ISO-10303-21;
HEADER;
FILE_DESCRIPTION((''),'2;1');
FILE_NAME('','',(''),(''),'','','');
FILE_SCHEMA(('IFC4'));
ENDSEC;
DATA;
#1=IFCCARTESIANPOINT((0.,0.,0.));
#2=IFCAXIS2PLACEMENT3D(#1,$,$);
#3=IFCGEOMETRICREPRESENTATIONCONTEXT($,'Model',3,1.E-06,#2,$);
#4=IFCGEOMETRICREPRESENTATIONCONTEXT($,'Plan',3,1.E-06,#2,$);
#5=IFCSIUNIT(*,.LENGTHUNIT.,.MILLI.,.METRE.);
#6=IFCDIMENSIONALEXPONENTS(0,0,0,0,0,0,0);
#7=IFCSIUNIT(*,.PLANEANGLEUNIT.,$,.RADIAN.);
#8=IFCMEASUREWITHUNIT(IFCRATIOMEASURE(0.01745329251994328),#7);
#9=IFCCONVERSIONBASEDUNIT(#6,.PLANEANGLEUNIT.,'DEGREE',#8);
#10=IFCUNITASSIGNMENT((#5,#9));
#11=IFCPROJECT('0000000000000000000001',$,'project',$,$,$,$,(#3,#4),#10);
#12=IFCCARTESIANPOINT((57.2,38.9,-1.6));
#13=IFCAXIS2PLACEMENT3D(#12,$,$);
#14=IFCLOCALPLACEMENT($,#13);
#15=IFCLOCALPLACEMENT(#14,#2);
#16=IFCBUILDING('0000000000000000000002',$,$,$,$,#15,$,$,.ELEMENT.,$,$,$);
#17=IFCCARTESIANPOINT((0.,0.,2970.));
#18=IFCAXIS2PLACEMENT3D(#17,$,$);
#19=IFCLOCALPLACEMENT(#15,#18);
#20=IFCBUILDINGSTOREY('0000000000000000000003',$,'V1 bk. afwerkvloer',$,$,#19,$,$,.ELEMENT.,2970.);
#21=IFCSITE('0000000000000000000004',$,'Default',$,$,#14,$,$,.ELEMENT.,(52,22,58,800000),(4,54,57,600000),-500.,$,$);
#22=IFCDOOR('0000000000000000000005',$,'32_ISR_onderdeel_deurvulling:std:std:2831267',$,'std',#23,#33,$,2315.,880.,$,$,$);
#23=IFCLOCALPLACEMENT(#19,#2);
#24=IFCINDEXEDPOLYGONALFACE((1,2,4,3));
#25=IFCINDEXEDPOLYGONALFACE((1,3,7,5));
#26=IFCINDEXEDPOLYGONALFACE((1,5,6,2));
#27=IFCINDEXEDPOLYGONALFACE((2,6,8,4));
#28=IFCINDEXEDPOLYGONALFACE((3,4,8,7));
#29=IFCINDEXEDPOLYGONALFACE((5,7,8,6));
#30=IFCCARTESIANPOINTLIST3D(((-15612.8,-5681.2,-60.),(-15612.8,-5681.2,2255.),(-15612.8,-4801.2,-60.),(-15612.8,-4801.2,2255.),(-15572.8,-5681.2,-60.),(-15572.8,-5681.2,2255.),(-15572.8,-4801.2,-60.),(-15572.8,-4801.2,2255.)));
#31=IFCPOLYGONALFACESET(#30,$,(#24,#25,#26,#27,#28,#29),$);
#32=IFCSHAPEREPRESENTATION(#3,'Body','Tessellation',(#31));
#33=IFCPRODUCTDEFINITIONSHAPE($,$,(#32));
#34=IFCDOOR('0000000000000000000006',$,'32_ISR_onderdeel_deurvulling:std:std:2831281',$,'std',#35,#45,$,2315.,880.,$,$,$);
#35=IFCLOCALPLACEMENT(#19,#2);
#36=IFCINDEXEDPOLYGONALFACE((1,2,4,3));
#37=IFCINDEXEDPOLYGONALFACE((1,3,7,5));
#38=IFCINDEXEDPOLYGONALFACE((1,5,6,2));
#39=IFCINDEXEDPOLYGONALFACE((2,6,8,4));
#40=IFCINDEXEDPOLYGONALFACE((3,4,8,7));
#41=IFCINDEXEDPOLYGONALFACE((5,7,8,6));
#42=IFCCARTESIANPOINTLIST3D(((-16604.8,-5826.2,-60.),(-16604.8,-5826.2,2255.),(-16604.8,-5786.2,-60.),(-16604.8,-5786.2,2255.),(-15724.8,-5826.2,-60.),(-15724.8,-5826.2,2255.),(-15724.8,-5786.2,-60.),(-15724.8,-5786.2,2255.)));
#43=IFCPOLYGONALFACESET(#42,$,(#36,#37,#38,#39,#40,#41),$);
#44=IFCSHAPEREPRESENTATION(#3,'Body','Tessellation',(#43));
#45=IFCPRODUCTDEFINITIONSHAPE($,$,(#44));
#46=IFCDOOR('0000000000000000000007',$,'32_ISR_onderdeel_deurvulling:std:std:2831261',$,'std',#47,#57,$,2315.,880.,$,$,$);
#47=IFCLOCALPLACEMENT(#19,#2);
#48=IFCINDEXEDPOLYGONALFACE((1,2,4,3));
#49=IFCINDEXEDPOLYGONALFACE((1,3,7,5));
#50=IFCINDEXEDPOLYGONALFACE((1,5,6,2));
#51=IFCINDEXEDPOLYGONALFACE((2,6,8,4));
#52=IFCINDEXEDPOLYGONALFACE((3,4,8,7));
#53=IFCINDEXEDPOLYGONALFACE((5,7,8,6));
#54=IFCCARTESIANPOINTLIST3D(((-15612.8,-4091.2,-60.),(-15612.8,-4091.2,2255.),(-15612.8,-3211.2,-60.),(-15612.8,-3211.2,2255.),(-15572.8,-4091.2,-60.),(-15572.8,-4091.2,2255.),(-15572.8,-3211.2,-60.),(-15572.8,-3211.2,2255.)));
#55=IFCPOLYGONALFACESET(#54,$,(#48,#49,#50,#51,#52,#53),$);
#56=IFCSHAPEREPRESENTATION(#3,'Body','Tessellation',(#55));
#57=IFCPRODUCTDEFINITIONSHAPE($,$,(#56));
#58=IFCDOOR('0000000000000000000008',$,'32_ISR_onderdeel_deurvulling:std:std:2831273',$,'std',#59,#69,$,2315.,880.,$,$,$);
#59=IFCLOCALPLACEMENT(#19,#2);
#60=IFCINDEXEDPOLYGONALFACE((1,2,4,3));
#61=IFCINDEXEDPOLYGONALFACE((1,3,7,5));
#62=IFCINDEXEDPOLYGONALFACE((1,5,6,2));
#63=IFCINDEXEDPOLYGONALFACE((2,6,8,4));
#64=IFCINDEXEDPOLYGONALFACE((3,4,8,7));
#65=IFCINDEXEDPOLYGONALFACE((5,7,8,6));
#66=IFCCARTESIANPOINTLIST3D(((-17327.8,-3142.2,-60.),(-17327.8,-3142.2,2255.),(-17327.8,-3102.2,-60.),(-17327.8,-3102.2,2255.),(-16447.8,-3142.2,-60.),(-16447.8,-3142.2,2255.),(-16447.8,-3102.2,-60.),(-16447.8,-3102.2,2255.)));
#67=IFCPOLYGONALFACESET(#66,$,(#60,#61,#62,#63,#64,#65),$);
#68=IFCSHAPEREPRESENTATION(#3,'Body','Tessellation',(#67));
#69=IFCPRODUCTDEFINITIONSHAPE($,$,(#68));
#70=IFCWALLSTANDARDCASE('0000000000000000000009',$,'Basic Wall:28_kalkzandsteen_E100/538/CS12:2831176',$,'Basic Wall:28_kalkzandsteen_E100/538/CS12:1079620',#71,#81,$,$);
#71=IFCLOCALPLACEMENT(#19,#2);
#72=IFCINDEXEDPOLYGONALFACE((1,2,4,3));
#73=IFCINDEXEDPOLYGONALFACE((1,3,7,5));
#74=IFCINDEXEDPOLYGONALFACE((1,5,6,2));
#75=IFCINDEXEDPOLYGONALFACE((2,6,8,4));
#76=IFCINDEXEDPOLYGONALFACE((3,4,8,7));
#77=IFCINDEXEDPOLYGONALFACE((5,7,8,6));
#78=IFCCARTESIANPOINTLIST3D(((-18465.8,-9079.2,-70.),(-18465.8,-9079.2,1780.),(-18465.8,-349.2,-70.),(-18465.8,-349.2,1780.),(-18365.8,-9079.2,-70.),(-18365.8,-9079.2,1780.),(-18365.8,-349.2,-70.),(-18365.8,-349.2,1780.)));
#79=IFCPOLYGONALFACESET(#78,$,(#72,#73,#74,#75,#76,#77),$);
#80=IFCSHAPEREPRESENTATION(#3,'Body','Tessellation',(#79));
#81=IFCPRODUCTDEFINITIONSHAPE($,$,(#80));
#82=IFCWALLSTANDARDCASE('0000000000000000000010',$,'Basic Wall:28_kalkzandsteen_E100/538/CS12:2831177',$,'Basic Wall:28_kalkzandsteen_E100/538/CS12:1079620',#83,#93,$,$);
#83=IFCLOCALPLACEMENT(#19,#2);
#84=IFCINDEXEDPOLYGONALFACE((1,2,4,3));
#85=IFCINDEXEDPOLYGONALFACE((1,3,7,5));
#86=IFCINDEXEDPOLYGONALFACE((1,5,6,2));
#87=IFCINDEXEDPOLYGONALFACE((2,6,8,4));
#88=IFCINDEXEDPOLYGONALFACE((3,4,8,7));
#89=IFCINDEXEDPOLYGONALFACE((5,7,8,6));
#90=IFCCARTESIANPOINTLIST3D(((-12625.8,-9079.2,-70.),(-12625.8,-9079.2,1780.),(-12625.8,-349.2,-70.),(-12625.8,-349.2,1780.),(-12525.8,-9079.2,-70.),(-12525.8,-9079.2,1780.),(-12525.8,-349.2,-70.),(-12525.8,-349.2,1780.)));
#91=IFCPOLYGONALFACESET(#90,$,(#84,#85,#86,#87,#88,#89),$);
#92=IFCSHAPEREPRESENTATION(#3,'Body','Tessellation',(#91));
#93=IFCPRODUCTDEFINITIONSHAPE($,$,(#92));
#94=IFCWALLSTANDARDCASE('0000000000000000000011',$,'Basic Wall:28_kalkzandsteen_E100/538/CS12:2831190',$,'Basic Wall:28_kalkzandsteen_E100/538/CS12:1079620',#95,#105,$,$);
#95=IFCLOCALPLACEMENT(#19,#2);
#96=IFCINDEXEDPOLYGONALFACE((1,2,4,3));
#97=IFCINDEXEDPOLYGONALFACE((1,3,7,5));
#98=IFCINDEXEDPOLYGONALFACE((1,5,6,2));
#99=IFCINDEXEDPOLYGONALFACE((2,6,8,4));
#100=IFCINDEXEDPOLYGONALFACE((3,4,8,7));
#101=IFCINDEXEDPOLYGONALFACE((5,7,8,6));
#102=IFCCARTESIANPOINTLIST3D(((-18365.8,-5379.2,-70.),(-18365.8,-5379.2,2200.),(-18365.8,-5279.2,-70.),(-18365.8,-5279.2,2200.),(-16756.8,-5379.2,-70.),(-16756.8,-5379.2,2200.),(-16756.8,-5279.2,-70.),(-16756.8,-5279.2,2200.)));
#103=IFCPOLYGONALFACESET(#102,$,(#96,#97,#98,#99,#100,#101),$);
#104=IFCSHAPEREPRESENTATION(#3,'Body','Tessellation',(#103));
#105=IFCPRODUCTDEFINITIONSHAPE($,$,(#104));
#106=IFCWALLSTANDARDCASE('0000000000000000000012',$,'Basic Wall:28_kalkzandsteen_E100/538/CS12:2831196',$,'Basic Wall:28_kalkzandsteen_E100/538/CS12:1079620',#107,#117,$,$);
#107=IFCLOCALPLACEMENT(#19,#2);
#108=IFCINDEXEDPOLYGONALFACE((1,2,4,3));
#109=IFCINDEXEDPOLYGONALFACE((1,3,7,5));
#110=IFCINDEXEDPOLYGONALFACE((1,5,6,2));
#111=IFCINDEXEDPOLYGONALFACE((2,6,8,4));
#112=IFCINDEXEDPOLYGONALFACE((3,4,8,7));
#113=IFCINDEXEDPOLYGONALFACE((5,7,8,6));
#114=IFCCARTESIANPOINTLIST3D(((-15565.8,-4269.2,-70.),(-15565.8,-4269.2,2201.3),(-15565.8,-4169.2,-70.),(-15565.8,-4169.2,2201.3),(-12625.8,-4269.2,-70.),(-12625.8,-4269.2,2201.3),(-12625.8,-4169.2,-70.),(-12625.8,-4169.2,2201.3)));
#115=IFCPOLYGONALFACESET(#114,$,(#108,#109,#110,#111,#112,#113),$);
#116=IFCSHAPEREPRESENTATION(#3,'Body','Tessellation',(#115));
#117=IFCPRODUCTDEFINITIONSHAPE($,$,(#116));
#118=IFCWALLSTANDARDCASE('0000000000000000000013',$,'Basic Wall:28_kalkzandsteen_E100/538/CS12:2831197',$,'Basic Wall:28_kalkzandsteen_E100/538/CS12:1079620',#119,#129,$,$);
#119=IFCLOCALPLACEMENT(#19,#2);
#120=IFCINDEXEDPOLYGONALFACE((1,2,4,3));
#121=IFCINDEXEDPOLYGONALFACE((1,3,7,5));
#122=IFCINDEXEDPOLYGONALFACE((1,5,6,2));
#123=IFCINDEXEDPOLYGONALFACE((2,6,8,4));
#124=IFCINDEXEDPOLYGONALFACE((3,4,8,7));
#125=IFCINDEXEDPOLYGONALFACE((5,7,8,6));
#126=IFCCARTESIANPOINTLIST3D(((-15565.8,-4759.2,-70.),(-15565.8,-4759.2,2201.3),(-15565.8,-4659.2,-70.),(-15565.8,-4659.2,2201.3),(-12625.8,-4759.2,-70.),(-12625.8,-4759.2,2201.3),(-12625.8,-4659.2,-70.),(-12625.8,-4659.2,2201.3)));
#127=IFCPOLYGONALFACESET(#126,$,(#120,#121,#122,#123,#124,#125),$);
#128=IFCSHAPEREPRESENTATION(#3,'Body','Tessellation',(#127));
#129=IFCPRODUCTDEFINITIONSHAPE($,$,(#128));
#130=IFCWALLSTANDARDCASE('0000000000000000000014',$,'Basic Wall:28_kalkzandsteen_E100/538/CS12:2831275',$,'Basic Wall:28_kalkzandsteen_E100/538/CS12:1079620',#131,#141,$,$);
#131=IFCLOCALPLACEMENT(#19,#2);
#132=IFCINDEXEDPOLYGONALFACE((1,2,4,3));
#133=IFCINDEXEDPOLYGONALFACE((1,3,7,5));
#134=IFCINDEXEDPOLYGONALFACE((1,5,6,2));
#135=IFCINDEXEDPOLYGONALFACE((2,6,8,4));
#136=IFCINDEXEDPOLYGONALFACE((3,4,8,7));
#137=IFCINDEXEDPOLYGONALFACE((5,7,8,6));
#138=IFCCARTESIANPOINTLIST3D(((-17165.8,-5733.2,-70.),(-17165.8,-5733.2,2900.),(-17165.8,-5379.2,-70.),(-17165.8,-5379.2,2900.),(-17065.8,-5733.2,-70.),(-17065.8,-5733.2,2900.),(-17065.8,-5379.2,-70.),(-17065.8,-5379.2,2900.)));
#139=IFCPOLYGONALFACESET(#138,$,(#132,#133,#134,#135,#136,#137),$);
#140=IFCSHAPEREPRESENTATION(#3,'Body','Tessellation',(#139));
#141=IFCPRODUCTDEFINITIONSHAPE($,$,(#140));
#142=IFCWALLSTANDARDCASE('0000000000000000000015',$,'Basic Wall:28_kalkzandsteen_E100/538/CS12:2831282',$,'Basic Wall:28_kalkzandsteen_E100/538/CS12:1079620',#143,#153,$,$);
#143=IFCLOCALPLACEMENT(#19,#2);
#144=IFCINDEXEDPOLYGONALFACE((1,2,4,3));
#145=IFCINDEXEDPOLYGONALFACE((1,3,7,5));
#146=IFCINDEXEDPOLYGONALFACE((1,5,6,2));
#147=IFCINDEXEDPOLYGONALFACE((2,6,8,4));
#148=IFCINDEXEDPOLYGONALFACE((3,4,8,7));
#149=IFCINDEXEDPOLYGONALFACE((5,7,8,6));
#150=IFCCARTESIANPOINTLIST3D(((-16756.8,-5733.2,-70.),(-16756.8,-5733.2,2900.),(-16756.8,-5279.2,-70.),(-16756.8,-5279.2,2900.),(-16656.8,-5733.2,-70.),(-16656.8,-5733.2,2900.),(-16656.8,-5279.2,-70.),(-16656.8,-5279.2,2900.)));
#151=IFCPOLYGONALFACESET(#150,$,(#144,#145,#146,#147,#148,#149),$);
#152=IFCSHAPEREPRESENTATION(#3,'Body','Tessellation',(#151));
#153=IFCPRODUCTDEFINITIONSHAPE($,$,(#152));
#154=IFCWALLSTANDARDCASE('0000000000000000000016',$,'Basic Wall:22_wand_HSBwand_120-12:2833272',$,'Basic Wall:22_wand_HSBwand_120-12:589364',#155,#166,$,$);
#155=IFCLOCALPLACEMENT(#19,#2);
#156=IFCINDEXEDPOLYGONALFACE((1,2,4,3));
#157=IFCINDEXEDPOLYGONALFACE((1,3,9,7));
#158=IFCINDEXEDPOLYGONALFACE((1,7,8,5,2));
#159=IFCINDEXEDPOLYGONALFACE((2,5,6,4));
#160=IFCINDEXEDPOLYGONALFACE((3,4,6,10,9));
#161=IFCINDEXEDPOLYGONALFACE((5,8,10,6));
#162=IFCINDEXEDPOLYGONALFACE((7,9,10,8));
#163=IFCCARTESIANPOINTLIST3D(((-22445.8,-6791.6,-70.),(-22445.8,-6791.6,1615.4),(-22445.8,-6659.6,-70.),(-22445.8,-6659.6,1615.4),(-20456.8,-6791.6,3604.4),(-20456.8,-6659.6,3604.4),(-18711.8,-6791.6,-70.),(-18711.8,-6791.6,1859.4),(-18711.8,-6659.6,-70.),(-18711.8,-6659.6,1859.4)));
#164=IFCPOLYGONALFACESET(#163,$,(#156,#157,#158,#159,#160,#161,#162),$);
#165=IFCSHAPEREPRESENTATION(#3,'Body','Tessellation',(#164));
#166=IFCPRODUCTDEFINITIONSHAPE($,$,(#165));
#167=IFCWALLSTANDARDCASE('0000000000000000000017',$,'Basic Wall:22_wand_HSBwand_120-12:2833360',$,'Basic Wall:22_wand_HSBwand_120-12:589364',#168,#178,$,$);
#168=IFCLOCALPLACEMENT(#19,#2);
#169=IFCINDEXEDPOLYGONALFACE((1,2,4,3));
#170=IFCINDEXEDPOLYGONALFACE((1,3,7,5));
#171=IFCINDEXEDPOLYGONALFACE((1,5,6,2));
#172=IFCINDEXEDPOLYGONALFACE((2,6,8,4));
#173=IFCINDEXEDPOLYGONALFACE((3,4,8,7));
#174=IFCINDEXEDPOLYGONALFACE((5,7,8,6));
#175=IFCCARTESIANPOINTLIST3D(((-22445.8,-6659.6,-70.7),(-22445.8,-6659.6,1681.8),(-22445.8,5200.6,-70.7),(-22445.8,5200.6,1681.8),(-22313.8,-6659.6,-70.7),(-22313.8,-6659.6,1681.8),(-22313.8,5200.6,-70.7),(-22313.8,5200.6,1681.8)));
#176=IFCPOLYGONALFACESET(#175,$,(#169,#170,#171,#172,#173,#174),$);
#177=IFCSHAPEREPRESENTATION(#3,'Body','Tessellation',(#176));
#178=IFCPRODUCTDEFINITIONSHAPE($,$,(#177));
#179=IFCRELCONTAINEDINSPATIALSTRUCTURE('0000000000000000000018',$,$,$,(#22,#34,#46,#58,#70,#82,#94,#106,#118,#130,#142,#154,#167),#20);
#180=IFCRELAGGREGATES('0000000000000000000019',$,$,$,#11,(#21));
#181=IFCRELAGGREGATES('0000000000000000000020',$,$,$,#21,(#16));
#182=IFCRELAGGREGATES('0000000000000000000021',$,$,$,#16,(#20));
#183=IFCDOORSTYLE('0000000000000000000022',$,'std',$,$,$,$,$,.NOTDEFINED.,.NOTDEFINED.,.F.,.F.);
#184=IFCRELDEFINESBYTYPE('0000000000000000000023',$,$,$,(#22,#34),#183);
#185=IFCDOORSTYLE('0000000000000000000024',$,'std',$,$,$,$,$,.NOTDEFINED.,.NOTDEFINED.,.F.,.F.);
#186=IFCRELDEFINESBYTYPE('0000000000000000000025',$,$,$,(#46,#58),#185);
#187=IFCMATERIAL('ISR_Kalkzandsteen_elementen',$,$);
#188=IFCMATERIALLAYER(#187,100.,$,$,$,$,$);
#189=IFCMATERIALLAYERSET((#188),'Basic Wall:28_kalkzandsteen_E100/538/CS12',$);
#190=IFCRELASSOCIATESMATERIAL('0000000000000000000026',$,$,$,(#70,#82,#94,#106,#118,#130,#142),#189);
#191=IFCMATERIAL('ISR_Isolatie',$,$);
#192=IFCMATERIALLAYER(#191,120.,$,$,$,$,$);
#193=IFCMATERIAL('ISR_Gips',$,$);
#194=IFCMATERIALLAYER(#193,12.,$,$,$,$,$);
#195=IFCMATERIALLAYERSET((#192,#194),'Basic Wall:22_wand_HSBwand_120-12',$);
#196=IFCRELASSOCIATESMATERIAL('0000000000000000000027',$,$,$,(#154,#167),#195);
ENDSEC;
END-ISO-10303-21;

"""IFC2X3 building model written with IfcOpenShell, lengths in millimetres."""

from ifc_helpers import new_model, entity, si_unit, converted_unit, frame, frame_2d, origin, origin_2d_with_axis, place, context, project, spatial, rectangle, extrude, clip, halfspace, source, transform, mapped, material, layer, layer_set, layer_usage, type_object, type_shapes, element, save


model = new_model("IFC2X3")

# Units and contexts
model_context = context("Model", 3, precision=1e-06, world=origin())
plan_context = context("Plan", 3, precision=1e-06, world=origin())
ifc_project = project(units=[si_unit("LENGTHUNIT", "METRE", prefix="MILLI"), converted_unit("PLANEANGLEUNIT", "DEGREE", entity("IfcRatioMeasure", 0.01745329251994328), si_unit("PLANEANGLEUNIT", "RADIAN"), dimensions=[0, 0, 0, 0, 0, 0, 0])], contexts=[model_context, plan_context])

# Site, building, storey
site_placement = place(None, frame((57.2, 38.9, -1.6)))
site = spatial("IfcSite", under=ifc_project, at=site_placement, Name="Default", CompositionType="ELEMENT", RefLatitude=(52, 22, 58, 800000), RefLongitude=(4, 54, 57, 600000), RefElevation=-500.0)
building_placement = place(site_placement, origin())
building = spatial("IfcBuilding", under=site, at=building_placement, CompositionType="ELEMENT")
storey_placement = place(building_placement, frame((0.0, 0.0, 2970.0)))
storey = spatial("IfcBuildingStorey", under=building, at=storey_placement, Name="V1 bk. afwerkvloer", CompositionType="ELEMENT", Elevation=2970.0)

# Doors
door_style_1 = type_object("IfcDoorStyle", Name="std", ConstructionType="NOTDEFINED", OperationType="NOTDEFINED", ParameterTakesPrecedence=False, Sizeable=False)
shared_shape_1 = source(origin(), model_context, "Body", "SweptSolid", [
    extrude(rectangle(XDim=880.0, YDim=40.0, at=origin_2d_with_axis()), frame((0.0, 34.0, 0.0)), (0.0, 0.0, 1.0), 2315.0),
])
type_shapes(door_style_1, [shared_shape_1])
door_1_placement = place(storey_placement, frame((-15558.8, -5241.2, -60.0), z_axis=(0.0, 0.0, 1.0), x_axis=(0.0, 1.0, 0.0)))
element("IfcDoor", 1, at=door_1_placement, inside=storey, type_object=door_style_1, Name="32_ISR_onderdeel_deurvulling:std:std:2831267", ObjectType="std", OverallHeight=2315.0, OverallWidth=880.0, context=model_context, shape_type="MappedRepresentation", body=[
    mapped(shared_shape_1, transform((0.0, 0.0, 0.0), scale=1.0)),
])
door_2_placement = place(storey_placement, frame((-16164.8, -5840.2, -60.0)))
element("IfcDoor", 2, at=door_2_placement, inside=storey, type_object=door_style_1, Name="32_ISR_onderdeel_deurvulling:std:std:2831281", ObjectType="std", OverallHeight=2315.0, OverallWidth=880.0, context=model_context, shape_type="MappedRepresentation", body=[
    mapped(shared_shape_1, transform((0.0, 0.0, 0.0), scale=1.0)),
])
door_style_2 = type_object("IfcDoorStyle", Name="std", ConstructionType="NOTDEFINED", OperationType="NOTDEFINED", ParameterTakesPrecedence=False, Sizeable=False)
shared_shape_2 = source(origin(), model_context, "Body", "SweptSolid", [
    extrude(rectangle(XDim=40.0, YDim=880.0, at=origin_2d_with_axis()), frame((0.0, -34.0, 0.0), z_axis=(0.0, 0.0, 1.0), x_axis=(0.0, -1.0, 0.0)), (0.0, 0.0, 1.0), 2315.0),
])
type_shapes(door_style_2, [shared_shape_2])
for number, where, z_axis, x_axis, name in (
    (3, (-15558.8, -3651.2, -60.0), (0.0, 0.0, 1.0), (0.0, -1.0, 0.0), "32_ISR_onderdeel_deurvulling:std:std:2831261"),
    (4, (-16887.8, -3156.2, -60.0), (0.0, 0.0, 1.0), (-1.0, 0.0, 0.0), "32_ISR_onderdeel_deurvulling:std:std:2831273"),
):
    element("IfcDoor", number, at=place(storey_placement, frame(where, z_axis=z_axis, x_axis=x_axis)), inside=storey, type_object=door_style_2, Name=name, ObjectType="std", OverallHeight=2315.0, OverallWidth=880.0, context=model_context, shape_type="MappedRepresentation", body=[
        mapped(shared_shape_2, transform((0.0, 0.0, 0.0), scale=1.0)),
    ])

# Shared definitions
ifc_material_1 = material(Name="ISR_Kalkzandsteen_elementen")
ifc_layer_1 = layer(ifc_material_1, 100.0)
ifc_layer_set_1 = layer_set([ifc_layer_1], Name="Basic Wall:28_kalkzandsteen_E100/538/CS12")

# Walls
ifc_layer_usage_1 = layer_usage(ifc_layer_set_1, "AXIS2", "POSITIVE", -50.0)
wall_1_placement = place(storey_placement, frame((-18415.8, -9079.2, -70.0), z_axis=(0.0, 0.0, 1.0), x_axis=(0.0, 1.0, 0.0)))
element("IfcWallStandardCase", 5, at=wall_1_placement, inside=storey, material=ifc_layer_usage_1, Name="Basic Wall:28_kalkzandsteen_E100/538/CS12:2831176", ObjectType="Basic Wall:28_kalkzandsteen_E100/538/CS12:1079620", context=model_context, shape_type="SweptSolid", body=[
    extrude(rectangle(XDim=8730.0, YDim=100.0, at=frame_2d((4365.0, 0.0), x_axis=(-1.0, 0.0))), origin(), (0.0, 0.0, 1.0), 1850.0),
])
ifc_layer_usage_2 = layer_usage(ifc_layer_set_1, "AXIS2", "POSITIVE", -50.0)
wall_2_placement = place(storey_placement, frame((-12575.8, -349.2, -70.0), z_axis=(0.0, 0.0, 1.0), x_axis=(0.0, -1.0, 0.0)))
element("IfcWallStandardCase", 6, at=wall_2_placement, inside=storey, material=ifc_layer_usage_2, Name="Basic Wall:28_kalkzandsteen_E100/538/CS12:2831177", ObjectType="Basic Wall:28_kalkzandsteen_E100/538/CS12:1079620", context=model_context, shape_type="SweptSolid", body=[
    extrude(rectangle(XDim=8730.0, YDim=100.0, at=frame_2d((4365.0, 0.0), x_axis=(-1.0, 0.0))), origin(), (0.0, 0.0, 1.0), 1850.0),
])

# Wall
ifc_layer_usage_3 = layer_usage(ifc_layer_set_1, "AXIS2", "NEGATIVE", 50.0)
wall_3_placement = place(storey_placement, frame((-16756.8, -5329.2, -70.0), z_axis=(0.0, 0.0, 1.0), x_axis=(-1.0, 0.0, 0.0)))
element("IfcWallStandardCase", 7, at=wall_3_placement, inside=storey, material=ifc_layer_usage_3, Name="Basic Wall:28_kalkzandsteen_E100/538/CS12:2831190", ObjectType="Basic Wall:28_kalkzandsteen_E100/538/CS12:1079620", context=model_context, shape_type="SweptSolid", body=[
    extrude(rectangle(XDim=1609.0, YDim=100.0, at=frame_2d((804.5, 0.0), x_axis=(-1.0, 0.0))), origin(), (0.0, 0.0, 1.0), 2270.0),
])

# Walls
ifc_layer_usage_4 = layer_usage(ifc_layer_set_1, "AXIS2", "NEGATIVE", 50.0)
wall_4_placement = place(storey_placement, frame((-12625.8, -4219.2, -70.0), z_axis=(0.0, 0.0, 1.0), x_axis=(-1.0, 0.0, 0.0)))
element("IfcWallStandardCase", 8, at=wall_4_placement, inside=storey, material=ifc_layer_usage_4, Name="Basic Wall:28_kalkzandsteen_E100/538/CS12:2831196", ObjectType="Basic Wall:28_kalkzandsteen_E100/538/CS12:1079620", context=model_context, shape_type="SweptSolid", body=[
    extrude(rectangle(XDim=2940.0, YDim=100.0, at=frame_2d((1470.0, 0.0), x_axis=(-1.0, 0.0))), origin(), (0.0, 0.0, 1.0), 2271.3),
])
ifc_layer_usage_5 = layer_usage(ifc_layer_set_1, "AXIS2", "NEGATIVE", 50.0)
wall_5_placement = place(storey_placement, frame((-12625.8, -4709.2, -70.0), z_axis=(0.0, 0.0, 1.0), x_axis=(-1.0, 0.0, 0.0)))
element("IfcWallStandardCase", 9, at=wall_5_placement, inside=storey, material=ifc_layer_usage_5, Name="Basic Wall:28_kalkzandsteen_E100/538/CS12:2831197", ObjectType="Basic Wall:28_kalkzandsteen_E100/538/CS12:1079620", context=model_context, shape_type="SweptSolid", body=[
    extrude(rectangle(XDim=2940.0, YDim=100.0, at=frame_2d((1470.0, 0.0), x_axis=(-1.0, 0.0))), origin(), (0.0, 0.0, 1.0), 2271.3),
])

# Walls
ifc_layer_usage_6 = layer_usage(ifc_layer_set_1, "AXIS2", "POSITIVE", -50.0)
wall_6_placement = place(storey_placement, frame((-17115.8, -5379.2, -70.0), z_axis=(0.0, 0.0, 1.0), x_axis=(0.0, -1.0, 0.0)))
element("IfcWallStandardCase", 10, at=wall_6_placement, inside=storey, material=ifc_layer_usage_6, Name="Basic Wall:28_kalkzandsteen_E100/538/CS12:2831275", ObjectType="Basic Wall:28_kalkzandsteen_E100/538/CS12:1079620", context=model_context, shape_type="SweptSolid", body=[
    extrude(rectangle(XDim=354.0, YDim=100.0, at=frame_2d((177.0, 0.0), x_axis=(-1.0, 0.0))), origin(), (0.0, 0.0, 1.0), 2970.0),
])
ifc_layer_usage_7 = layer_usage(ifc_layer_set_1, "AXIS2", "POSITIVE", -50.0)
wall_7_placement = place(storey_placement, frame((-16706.8, -5733.2, -70.0), z_axis=(0.0, 0.0, 1.0), x_axis=(0.0, 1.0, 0.0)))
element("IfcWallStandardCase", 11, at=wall_7_placement, inside=storey, material=ifc_layer_usage_7, Name="Basic Wall:28_kalkzandsteen_E100/538/CS12:2831282", ObjectType="Basic Wall:28_kalkzandsteen_E100/538/CS12:1079620", context=model_context, shape_type="SweptSolid", body=[
    extrude(rectangle(XDim=454.0, YDim=100.0, at=frame_2d((227.0, 0.0), x_axis=(-1.0, 0.0))), origin(), (0.0, 0.0, 1.0), 2970.0),
])
ifc_material_2 = material(Name="ISR_Isolatie")
ifc_layer_2 = layer(ifc_material_2, 120.0)
ifc_material_3 = material(Name="ISR_Gips")
ifc_layer_3 = layer(ifc_material_3, 12.0)
ifc_layer_set_2 = layer_set([ifc_layer_2, ifc_layer_3], Name="Basic Wall:22_wand_HSBwand_120-12")
ifc_layer_usage_8 = layer_usage(ifc_layer_set_2, "AXIS2", "NEGATIVE", 66.0)
wall_8_placement = place(storey_placement, frame((-18711.8, -6725.6, -70.0), z_axis=(0.0, 0.0, 1.0), x_axis=(-1.0, 0.0, 0.0)))
element("IfcWallStandardCase", 12, at=wall_8_placement, inside=storey, material=ifc_layer_usage_8, Name="Basic Wall:22_wand_HSBwand_120-12:2833272", ObjectType="Basic Wall:22_wand_HSBwand_120-12:589364", context=model_context, shape_type="Clipping", body=[
    clip(clip(extrude(rectangle(XDim=3734.0, YDim=132.0, at=frame_2d((1867.0, 0.0), x_axis=(-1.0, 0.0))), origin(), (0.0, 0.0, 1.0), 3674.4), halfspace(frame((1745.0, -66.0, 3674.4), z_axis=(0.707107, 0.0, 0.707107), x_axis=(0.0, 1.0, 0.0)), False)), halfspace(frame((0.0, -66.0, 1929.4), z_axis=(-0.707107, 0.0, 0.707107), x_axis=(0.0, 1.0, 0.0)), False)),
])
ifc_layer_usage_9 = layer_usage(ifc_layer_set_2, "AXIS2", "NEGATIVE", 66.0)
wall_9_placement = place(storey_placement, frame((-22379.8, -6659.6, -70.7), z_axis=(0.0, 0.0, 1.0), x_axis=(0.0, 1.0, 0.0)))
element("IfcWallStandardCase", 13, at=wall_9_placement, inside=storey, material=ifc_layer_usage_9, Name="Basic Wall:22_wand_HSBwand_120-12:2833360", ObjectType="Basic Wall:22_wand_HSBwand_120-12:589364", context=model_context, shape_type="SweptSolid", body=[
    extrude(rectangle(XDim=11860.3, YDim=132.0, at=frame_2d((5930.1, 0.0), x_axis=(-1.0, 0.0))), origin(), (0.0, 0.0, 1.0), 1752.5),
])

save(model, "model.ifc")
